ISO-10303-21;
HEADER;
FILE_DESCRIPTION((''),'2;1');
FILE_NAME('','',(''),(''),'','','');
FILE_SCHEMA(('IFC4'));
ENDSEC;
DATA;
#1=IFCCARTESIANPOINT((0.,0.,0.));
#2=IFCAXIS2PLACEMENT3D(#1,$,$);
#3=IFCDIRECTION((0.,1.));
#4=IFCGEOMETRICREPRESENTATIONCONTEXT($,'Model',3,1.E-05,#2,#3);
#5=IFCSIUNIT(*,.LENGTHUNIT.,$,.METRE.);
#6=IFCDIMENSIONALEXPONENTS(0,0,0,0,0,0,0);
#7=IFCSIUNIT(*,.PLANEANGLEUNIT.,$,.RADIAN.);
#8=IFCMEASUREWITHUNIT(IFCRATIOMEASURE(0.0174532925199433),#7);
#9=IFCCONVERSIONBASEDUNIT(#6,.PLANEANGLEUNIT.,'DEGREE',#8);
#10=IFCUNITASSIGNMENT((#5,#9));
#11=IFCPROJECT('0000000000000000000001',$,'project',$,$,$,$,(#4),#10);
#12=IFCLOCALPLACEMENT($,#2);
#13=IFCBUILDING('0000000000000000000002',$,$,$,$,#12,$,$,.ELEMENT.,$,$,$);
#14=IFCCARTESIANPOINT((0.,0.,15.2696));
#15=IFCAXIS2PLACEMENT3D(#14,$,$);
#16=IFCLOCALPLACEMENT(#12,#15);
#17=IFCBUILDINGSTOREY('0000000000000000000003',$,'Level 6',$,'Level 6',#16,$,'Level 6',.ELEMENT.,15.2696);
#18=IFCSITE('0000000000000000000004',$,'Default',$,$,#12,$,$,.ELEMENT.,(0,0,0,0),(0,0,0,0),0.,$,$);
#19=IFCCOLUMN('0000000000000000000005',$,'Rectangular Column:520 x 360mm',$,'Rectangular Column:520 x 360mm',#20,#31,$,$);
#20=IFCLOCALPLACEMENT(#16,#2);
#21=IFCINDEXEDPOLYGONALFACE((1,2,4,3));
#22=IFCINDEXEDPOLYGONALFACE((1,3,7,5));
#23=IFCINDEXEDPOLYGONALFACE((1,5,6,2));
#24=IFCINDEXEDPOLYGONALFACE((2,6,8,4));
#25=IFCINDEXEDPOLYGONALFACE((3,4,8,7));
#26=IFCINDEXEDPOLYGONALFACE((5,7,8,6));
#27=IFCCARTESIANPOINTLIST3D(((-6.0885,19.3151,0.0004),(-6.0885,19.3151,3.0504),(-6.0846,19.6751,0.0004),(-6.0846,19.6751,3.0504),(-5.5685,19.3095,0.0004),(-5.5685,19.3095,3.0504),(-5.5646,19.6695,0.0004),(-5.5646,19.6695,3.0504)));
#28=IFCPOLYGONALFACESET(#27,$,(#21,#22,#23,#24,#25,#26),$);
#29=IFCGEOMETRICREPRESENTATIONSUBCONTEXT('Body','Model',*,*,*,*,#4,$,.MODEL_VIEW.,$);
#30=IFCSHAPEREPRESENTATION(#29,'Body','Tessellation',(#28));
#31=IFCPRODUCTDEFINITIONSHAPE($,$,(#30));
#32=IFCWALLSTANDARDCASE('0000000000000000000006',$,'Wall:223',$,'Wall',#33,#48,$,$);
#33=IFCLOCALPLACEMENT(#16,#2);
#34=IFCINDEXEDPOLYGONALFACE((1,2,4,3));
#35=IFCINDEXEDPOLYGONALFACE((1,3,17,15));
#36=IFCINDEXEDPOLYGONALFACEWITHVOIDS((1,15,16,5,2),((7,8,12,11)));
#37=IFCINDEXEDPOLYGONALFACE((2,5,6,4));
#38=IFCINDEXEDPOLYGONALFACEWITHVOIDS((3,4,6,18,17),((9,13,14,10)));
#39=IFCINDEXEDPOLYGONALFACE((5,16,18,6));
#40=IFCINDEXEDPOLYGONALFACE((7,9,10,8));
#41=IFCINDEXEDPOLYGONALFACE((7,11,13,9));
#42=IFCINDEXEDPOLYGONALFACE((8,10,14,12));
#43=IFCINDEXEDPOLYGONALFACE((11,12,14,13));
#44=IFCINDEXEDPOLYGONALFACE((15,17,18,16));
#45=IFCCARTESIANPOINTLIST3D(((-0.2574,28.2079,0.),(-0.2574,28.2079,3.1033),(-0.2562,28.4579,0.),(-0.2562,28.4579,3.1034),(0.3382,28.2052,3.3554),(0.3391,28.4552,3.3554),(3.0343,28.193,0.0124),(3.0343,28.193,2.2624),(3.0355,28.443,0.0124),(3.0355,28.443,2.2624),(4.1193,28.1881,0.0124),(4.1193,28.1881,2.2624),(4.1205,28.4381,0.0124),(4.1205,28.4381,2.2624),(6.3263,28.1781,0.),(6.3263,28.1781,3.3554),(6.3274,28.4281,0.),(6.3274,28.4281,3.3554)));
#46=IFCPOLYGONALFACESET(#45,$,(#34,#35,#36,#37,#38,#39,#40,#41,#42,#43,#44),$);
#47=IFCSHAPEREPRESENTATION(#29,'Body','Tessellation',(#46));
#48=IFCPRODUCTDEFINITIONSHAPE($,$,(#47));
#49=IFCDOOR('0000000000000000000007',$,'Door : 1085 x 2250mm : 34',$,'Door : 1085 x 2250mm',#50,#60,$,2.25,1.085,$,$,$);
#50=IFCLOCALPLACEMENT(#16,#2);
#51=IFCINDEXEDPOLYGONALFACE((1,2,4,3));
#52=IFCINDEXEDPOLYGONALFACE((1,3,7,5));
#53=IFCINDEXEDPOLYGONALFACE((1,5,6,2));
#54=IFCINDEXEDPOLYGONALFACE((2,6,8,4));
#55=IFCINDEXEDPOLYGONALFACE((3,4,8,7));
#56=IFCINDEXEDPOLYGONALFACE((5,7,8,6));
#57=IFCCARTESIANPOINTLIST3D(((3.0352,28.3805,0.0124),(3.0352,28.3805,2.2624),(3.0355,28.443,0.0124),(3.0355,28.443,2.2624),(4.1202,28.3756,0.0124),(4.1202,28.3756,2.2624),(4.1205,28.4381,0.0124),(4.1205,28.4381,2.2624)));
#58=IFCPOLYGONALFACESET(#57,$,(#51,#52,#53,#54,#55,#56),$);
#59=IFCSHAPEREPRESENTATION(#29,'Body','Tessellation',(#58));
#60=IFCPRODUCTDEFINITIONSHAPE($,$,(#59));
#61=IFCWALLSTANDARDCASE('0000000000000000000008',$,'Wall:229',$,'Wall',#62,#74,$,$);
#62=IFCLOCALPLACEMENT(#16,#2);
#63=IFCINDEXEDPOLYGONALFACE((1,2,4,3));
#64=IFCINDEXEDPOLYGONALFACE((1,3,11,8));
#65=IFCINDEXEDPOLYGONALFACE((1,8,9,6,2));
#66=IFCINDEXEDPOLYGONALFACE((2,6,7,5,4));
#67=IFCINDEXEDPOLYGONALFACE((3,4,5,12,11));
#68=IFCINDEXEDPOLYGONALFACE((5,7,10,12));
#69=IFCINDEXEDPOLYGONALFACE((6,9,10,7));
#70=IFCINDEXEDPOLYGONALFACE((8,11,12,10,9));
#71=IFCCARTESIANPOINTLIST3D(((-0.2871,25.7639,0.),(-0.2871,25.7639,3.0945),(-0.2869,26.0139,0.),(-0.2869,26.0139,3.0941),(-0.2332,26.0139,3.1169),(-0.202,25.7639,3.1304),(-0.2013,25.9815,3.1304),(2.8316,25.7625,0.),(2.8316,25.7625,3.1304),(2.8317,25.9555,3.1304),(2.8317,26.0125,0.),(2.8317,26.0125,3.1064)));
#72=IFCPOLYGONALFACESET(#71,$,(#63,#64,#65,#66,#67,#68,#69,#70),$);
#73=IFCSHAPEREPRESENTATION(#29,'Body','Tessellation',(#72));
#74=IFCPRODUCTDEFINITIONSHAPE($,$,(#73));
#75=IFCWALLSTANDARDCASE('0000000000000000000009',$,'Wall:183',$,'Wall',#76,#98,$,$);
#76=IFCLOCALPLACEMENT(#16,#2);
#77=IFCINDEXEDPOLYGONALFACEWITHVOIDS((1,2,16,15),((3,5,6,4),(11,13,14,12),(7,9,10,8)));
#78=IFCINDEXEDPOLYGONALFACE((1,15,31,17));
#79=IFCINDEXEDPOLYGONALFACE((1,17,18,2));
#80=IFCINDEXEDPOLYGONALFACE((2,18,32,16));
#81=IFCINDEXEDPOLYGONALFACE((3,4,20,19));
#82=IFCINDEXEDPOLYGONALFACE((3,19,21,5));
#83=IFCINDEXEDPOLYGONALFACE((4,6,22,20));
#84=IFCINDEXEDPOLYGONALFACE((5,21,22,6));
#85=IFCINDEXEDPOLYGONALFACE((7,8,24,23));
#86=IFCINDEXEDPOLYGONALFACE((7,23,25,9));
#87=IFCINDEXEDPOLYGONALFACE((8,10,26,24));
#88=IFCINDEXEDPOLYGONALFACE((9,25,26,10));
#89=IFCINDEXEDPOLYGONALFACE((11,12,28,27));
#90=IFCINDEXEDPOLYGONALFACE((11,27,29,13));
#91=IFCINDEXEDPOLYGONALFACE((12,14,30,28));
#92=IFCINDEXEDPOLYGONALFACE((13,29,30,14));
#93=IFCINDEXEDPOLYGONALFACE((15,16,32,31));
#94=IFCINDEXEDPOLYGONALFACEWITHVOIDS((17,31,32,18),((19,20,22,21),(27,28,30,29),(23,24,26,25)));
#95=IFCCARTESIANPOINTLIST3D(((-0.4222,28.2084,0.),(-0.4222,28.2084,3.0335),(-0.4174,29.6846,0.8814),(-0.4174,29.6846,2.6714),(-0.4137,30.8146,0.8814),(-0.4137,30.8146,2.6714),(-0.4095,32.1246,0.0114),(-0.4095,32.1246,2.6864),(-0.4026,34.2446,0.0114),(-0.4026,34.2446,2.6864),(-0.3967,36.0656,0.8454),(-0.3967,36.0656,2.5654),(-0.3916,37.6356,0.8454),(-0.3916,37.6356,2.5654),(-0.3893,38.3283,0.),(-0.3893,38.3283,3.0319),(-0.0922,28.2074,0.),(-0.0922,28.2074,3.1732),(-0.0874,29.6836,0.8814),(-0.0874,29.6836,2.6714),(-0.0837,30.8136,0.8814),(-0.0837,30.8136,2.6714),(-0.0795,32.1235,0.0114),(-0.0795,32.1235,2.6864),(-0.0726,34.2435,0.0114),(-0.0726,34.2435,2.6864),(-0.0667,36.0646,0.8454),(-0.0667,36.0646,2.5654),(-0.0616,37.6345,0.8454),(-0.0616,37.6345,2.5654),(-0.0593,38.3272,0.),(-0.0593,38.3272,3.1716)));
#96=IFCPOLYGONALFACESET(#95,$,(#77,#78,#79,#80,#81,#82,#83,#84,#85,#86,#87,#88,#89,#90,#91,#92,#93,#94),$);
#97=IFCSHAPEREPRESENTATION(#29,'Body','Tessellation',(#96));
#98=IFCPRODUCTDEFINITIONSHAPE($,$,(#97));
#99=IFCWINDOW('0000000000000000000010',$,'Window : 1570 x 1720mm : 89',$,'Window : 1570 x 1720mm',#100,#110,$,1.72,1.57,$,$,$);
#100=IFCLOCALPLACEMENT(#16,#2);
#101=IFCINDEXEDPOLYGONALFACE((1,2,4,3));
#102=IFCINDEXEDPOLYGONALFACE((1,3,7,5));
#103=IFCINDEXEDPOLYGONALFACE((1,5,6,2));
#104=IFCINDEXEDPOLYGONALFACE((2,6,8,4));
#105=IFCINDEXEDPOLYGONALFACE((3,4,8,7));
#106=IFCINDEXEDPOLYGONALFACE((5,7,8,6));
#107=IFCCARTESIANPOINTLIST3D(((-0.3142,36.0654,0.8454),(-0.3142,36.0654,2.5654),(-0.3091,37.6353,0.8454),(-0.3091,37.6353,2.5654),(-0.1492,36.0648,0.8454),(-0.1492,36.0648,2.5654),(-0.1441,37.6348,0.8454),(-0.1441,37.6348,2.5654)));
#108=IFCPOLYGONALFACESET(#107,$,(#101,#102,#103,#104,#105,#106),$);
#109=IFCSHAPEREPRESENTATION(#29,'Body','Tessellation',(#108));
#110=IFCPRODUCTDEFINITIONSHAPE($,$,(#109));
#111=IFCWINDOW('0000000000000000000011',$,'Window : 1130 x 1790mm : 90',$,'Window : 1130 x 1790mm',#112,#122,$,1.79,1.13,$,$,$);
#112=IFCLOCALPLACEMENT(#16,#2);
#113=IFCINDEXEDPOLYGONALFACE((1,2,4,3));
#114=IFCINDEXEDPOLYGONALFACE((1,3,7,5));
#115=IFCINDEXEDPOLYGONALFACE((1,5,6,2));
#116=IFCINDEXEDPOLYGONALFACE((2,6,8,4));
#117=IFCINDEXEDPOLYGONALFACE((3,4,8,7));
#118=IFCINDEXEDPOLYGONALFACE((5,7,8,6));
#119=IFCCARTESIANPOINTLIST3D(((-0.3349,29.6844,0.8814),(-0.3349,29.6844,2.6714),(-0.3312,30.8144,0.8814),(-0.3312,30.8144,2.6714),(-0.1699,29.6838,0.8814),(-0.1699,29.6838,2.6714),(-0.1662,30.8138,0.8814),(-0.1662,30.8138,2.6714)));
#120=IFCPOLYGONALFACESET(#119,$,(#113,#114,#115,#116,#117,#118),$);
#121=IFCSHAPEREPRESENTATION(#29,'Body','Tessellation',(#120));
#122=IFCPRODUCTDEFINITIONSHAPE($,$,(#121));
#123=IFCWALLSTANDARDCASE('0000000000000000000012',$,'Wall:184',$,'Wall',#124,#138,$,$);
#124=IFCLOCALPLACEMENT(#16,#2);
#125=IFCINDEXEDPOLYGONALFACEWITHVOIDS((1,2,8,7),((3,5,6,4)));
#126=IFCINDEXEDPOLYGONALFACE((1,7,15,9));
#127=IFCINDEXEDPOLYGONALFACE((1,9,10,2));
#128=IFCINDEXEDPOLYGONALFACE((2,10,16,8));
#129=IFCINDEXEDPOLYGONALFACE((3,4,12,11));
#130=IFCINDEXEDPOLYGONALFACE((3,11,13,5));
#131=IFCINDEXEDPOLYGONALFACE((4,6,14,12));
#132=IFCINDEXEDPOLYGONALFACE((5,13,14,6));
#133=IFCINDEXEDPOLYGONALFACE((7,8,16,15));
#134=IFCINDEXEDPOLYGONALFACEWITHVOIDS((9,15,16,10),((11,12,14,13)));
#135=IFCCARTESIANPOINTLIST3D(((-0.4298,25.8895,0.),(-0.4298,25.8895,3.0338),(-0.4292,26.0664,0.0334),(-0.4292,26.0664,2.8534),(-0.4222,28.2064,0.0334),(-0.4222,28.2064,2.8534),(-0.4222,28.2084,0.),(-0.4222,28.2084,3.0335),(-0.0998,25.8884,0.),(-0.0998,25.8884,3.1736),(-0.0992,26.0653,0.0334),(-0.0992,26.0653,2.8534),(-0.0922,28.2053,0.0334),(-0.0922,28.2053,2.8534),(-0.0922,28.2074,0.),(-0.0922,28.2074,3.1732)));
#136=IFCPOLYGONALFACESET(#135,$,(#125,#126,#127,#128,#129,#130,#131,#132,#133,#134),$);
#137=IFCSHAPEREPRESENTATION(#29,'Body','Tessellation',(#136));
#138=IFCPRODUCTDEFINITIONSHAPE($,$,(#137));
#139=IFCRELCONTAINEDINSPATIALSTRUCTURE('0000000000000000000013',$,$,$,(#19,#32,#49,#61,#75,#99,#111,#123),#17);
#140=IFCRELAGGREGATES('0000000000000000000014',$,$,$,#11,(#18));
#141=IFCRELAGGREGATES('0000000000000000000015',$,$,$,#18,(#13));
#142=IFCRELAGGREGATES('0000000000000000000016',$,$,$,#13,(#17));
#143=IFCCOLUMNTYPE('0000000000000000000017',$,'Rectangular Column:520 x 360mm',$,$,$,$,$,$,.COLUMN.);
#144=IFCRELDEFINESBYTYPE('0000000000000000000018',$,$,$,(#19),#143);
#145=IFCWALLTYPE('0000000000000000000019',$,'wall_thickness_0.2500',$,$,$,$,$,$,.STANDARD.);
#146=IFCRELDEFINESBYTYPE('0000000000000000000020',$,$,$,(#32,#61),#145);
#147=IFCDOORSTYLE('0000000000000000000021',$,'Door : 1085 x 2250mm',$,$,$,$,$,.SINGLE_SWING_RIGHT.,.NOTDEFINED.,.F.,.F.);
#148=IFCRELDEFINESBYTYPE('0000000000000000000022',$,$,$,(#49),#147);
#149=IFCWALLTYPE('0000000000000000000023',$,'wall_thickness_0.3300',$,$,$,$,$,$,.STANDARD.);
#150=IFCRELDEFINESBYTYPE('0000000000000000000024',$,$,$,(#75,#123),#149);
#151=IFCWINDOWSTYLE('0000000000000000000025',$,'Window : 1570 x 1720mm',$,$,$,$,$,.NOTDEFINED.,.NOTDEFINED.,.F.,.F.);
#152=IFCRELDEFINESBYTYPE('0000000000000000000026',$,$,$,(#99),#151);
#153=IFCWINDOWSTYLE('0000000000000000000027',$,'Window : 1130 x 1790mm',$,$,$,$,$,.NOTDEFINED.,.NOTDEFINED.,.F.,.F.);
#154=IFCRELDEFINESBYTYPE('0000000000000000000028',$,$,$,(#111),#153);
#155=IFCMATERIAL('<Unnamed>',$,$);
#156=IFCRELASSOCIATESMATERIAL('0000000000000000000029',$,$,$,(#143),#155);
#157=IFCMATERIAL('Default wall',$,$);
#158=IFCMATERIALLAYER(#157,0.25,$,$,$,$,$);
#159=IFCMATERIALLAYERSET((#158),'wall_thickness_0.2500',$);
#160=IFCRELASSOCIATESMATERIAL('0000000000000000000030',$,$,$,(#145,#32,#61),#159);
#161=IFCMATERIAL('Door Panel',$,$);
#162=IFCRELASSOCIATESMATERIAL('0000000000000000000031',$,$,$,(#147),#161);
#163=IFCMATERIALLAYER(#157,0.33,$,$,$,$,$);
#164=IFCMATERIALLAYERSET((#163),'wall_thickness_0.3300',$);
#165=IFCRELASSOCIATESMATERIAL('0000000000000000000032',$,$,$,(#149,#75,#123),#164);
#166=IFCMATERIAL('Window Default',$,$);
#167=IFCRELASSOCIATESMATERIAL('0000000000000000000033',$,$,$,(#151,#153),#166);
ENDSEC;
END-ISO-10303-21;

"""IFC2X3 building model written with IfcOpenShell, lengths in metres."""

from ifc_helpers import new_model, entity, si_unit, converted_unit, direction, frame, frame_2d, origin, origin_2d_with_axis, place, context, subcontext, project, spatial, polyline, rectangle, outline, extrude, clip, halfspace, source, transform, mapped, material, layer, layer_set, layer_usage, type_object, type_shapes, element, fill, save


model = new_model("IFC2X3")

# Units and contexts
model_context = context("Model", 3, precision=1e-05, world=origin(), true_north=direction((0.0, 1.0)))
body_context = subcontext(model_context, "Body", "Model", "MODEL_VIEW")
ifc_project = project(units=[si_unit("LENGTHUNIT", "METRE"), converted_unit("PLANEANGLEUNIT", "DEGREE", entity("IfcRatioMeasure", 0.0174532925199433), si_unit("PLANEANGLEUNIT", "RADIAN"), dimensions=[0, 0, 0, 0, 0, 0, 0])], contexts=[model_context])

# Site, building, storey
placement = place(None, origin())
site = spatial("IfcSite", under=ifc_project, at=placement, Name="Default", CompositionType="ELEMENT", RefLatitude=(0, 0, 0, 0), RefLongitude=(0, 0, 0, 0), RefElevation=0.0)
building = spatial("IfcBuilding", under=site, at=placement, CompositionType="ELEMENT")
storey_placement = place(placement, frame((0.0, 0.0, 15.2696)))
storey = spatial("IfcBuildingStorey", under=building, at=storey_placement, Name="Level 6", ObjectType="Level 6", LongName="Level 6", CompositionType="ELEMENT", Elevation=15.2696)

# Column
ifc_material_1 = material(Name="<Unnamed>")
column_type = type_object("IfcColumnType", Name="Rectangular Column:520 x 360mm", PredefinedType="COLUMN", material=ifc_material_1)
shared_shape_1 = source(origin(), body_context, "Body", "SweptSolid", [
    extrude(rectangle(XDim=0.52, YDim=0.36, at=origin_2d_with_axis()), frame((0.0, 0.0, 0.0), z_axis=(0.0, 0.0, 1.0), x_axis=(0.0, -1.0, 0.0)), (0.0, 0.0, 1.0), 3.05),
])
type_shapes(column_type, [shared_shape_1])
column_placement = place(placement, frame((-5.8266, 19.4923, 15.27), z_axis=(0.0, 0.0, 1.0), x_axis=(-0.010821, -0.999941, 0.0)))
element("IfcColumn", 1, at=column_placement, inside=storey, type_object=column_type, Name="Rectangular Column:520 x 360mm", ObjectType="Rectangular Column:520 x 360mm", context=body_context, shape_type="MappedRepresentation", body=[
    mapped(shared_shape_1, transform((0.0, 0.0, 0.0), scale=1.0)),
])

# Shared definitions
ifc_material_2 = material(Name="Default wall")
ifc_layer_1 = layer(ifc_material_2, 0.25)
ifc_layer_set_1 = layer_set([ifc_layer_1], Name="wall_thickness_0.2500")
ifc_layer_usage_1 = layer_usage(ifc_layer_set_1, "AXIS2", "POSITIVE", -0.125)
wall_type_1 = type_object("IfcWallType", Name="wall_thickness_0.2500", PredefinedType="STANDARD", material=ifc_layer_set_1)

# Wall, opening, door
wall_1_placement = place(storey_placement, frame((-0.2568, 28.3329, 0.0), z_axis=(0.0, 0.0, 1.0), x_axis=(0.99999, -0.00453, 0.0)))
wall_1 = element("IfcWallStandardCase", 2, at=wall_1_placement, inside=storey, type_object=wall_type_1, material=ifc_layer_usage_1, Name="Wall:223", ObjectType="Wall", context=body_context, shape_type="Clipping", body=[
    clip(extrude(outline(polyline([(6.5837, -0.125), (6.5837, 0.125), (0.0, 0.125), (0.0, -0.125), (6.5837, -0.125)])), origin(), (0.0, 0.0, 1.0), 3.3554), halfspace(frame((-1.2212, 47.5059, 2.6044), z_axis=(-0.389901, -0.000352, 0.920857), x_axis=(0.920855, -0.001376, 0.389903)), False)),
])
opening_1_placement = place(wall_1_placement, frame((3.2917, -0.125, 0.0124)))
opening_1 = element("IfcOpeningElement", 3, at=opening_1_placement, cuts=wall_1, ObjectType="Opening", context=body_context, shape_type="SweptSolid", body=[
    extrude(rectangle(XDim=1.085, YDim=2.25, at=frame_2d((1.125, 0.5425), x_axis=(0.0, 1.0))), frame((0.0, 0.0, 0.0), z_axis=(0.0, 1.0, 0.0), x_axis=(0.0, 0.0, 1.0)), (0.0, 0.0, 1.0), 0.25),
])
ifc_material_3 = material(Name="Door Panel")
door_style_1 = type_object("IfcDoorStyle", Name="Door : 1085 x 2250mm", ConstructionType="NOTDEFINED", OperationType="SINGLE_SWING_RIGHT", ParameterTakesPrecedence=False, Sizeable=False, material=ifc_material_3)
shared_shape_2 = source(origin(), body_context, "Body", "SweptSolid", [
    extrude(rectangle(XDim=0.0625, YDim=1.085, at=origin_2d_with_axis()), frame((0.5425, 0.2188, 0.0), z_axis=(0.0, 0.0, 1.0), x_axis=(0.0, 1.0, 0.0)), (0.0, 0.0, 1.0), 2.25),
])
type_shapes(door_style_1, [shared_shape_2])
door_1_placement = place(opening_1_placement, origin())
door_1 = element("IfcDoor", 4, at=door_1_placement, inside=storey, type_object=door_style_1, Name="Door : 1085 x 2250mm : 34", ObjectType="Door : 1085 x 2250mm", OverallHeight=2.25, OverallWidth=1.085, context=body_context, shape_type="MappedRepresentation", body=[
    mapped(shared_shape_2, transform((0.0, 0.0, 0.0), scale=1.0)),
])
fill(opening_1, door_1)

# Wall
wall_2_placement = place(storey_placement, frame((-0.287, 25.8889, 0.0), z_axis=(0.0, 0.0, 1.0), x_axis=(1.0, -0.000475, 0.0)))
element("IfcWallStandardCase", 5, at=wall_2_placement, inside=storey, type_object=wall_type_1, material=ifc_layer_usage_1, Name="Wall:229", ObjectType="Wall", context=body_context, shape_type="Clipping", body=[
    clip(clip(extrude(outline(polyline([(3.1187, -0.125), (3.1187, 0.125), (0.0, 0.125), (0.0, -0.125), (3.1187, -0.125)])), origin(), (0.0, 0.0, 1.0), 3.1304), halfspace(frame((24.6699, -6.6404, 5.8904), z_axis=(0.003154, 0.389123, 0.92118), x_axis=(-0.999956, 0.009332, -0.000518)), False)), halfspace(frame((-0.9995, 49.9544, 2.6044), z_axis=(-0.389899, 0.001229, 0.920857), x_axis=(0.920842, -0.00511, 0.389903)), False)),
])

# Wall, openings, windows
ifc_layer_2 = layer(ifc_material_2, 0.33)
ifc_layer_set_2 = layer_set([ifc_layer_2], Name="wall_thickness_0.3300")
ifc_layer_usage_2 = layer_usage(ifc_layer_set_2, "AXIS2", "POSITIVE", -0.165)
wall_type_2 = type_object("IfcWallType", Name="wall_thickness_0.3300", PredefinedType="STANDARD", material=ifc_layer_set_2)
wall_3_placement = place(storey_placement, frame((-0.2243, 38.3278, 0.0), z_axis=(0.0, 0.0, 1.0), x_axis=(-0.003252, -0.999995, 0.0)))
wall_3 = element("IfcWallStandardCase", 6, at=wall_3_placement, inside=storey, type_object=wall_type_2, material=ifc_layer_usage_2, Name="Wall:183", ObjectType="Wall", context=body_context, shape_type="Clipping", body=[
    clip(extrude(outline(polyline([(10.1199, -0.165), (10.1199, 0.165), (0.0, 0.165), (0.0, -0.165), (10.1199, -0.165)])), origin(), (0.0, 0.0, 1.0), 3.1904), halfspace(frame((-37.5125, -1.1605, 2.6044), z_axis=(-0.000147, -0.389901, 0.920857), x_axis=(0.002553, 0.920852, 0.389903)), False)),
])
opening_2_placement = place(wall_3_placement, frame((4.0837, -0.165, 0.0114)))
element("IfcOpeningElement", 7, at=opening_2_placement, cuts=wall_3, ObjectType="Opening", context=body_context, shape_type="SweptSolid", body=[
    extrude(rectangle(XDim=2.12, YDim=2.675, at=frame_2d((1.3375, 1.06), x_axis=(0.0, 1.0))), frame((0.0, 0.0, 0.0), z_axis=(0.0, 1.0, 0.0), x_axis=(0.0, 0.0, 1.0)), (0.0, 0.0, 1.0), 0.33),
])
opening_3_placement = place(wall_3_placement, frame((0.6927, -0.165, 0.8454)))
opening_3 = element("IfcOpeningElement", 8, at=opening_3_placement, cuts=wall_3, ObjectType="Opening", context=body_context, shape_type="SweptSolid", body=[
    extrude(rectangle(XDim=1.57, YDim=1.72, at=frame_2d((0.86, 0.785), x_axis=(0.0, 1.0))), frame((0.0, 0.0, 0.0), z_axis=(0.0, 1.0, 0.0), x_axis=(0.0, 0.0, 1.0)), (0.0, 0.0, 1.0), 0.33),
])
opening_4_placement = place(wall_3_placement, frame((7.5137, -0.165, 0.8814)))
opening_4 = element("IfcOpeningElement", 9, at=opening_4_placement, cuts=wall_3, ObjectType="Opening", context=body_context, shape_type="SweptSolid", body=[
    extrude(rectangle(XDim=1.13, YDim=1.79, at=frame_2d((0.895, 0.565), x_axis=(0.0, 1.0))), frame((0.0, 0.0, 0.0), z_axis=(0.0, 1.0, 0.0), x_axis=(0.0, 0.0, 1.0)), (0.0, 0.0, 1.0), 0.33),
])
ifc_material_4 = material(Name="Window Default")
window_style_1 = type_object("IfcWindowStyle", Name="Window : 1570 x 1720mm", ConstructionType="NOTDEFINED", OperationType="NOTDEFINED", ParameterTakesPrecedence=False, Sizeable=False, material=ifc_material_4)
shared_shape_3 = source(origin(), body_context, "Body", "SweptSolid", [
    extrude(rectangle(XDim=0.165, YDim=1.57, at=origin_2d_with_axis()), frame((0.785, 0.165, 0.0), z_axis=(0.0, 0.0, 1.0), x_axis=(0.0, 1.0, 0.0)), (0.0, 0.0, 1.0), 1.72),
])
type_shapes(window_style_1, [shared_shape_3])
window_1_placement = place(opening_3_placement, origin())
window_1 = element("IfcWindow", 10, at=window_1_placement, inside=storey, type_object=window_style_1, Name="Window : 1570 x 1720mm : 89", ObjectType="Window : 1570 x 1720mm", OverallHeight=1.72, OverallWidth=1.57, context=body_context, shape_type="MappedRepresentation", body=[
    mapped(shared_shape_3, transform((0.0, 0.0, 0.0), scale=1.0)),
])
fill(opening_3, window_1)
window_style_2 = type_object("IfcWindowStyle", Name="Window : 1130 x 1790mm", ConstructionType="NOTDEFINED", OperationType="NOTDEFINED", ParameterTakesPrecedence=False, Sizeable=False, material=ifc_material_4)
shared_shape_4 = source(origin(), body_context, "Body", "SweptSolid", [
    extrude(rectangle(XDim=0.165, YDim=1.13, at=origin_2d_with_axis()), frame((0.565, 0.165, 0.0), z_axis=(0.0, 0.0, 1.0), x_axis=(0.0, 1.0, 0.0)), (0.0, 0.0, 1.0), 1.79),
])
type_shapes(window_style_2, [shared_shape_4])
window_2_placement = place(opening_4_placement, origin())
window_2 = element("IfcWindow", 11, at=window_2_placement, inside=storey, type_object=window_style_2, Name="Window : 1130 x 1790mm : 90", ObjectType="Window : 1130 x 1790mm", OverallHeight=1.79, OverallWidth=1.13, context=body_context, shape_type="MappedRepresentation", body=[
    mapped(shared_shape_4, transform((0.0, 0.0, 0.0), scale=1.0)),
])
fill(opening_4, window_2)

# Wall, opening
wall_4_placement = place(storey_placement, frame((-0.2572, 28.2079, 0.0), z_axis=(0.0, 0.0, 1.0), x_axis=(-0.003252, -0.999995, 0.0)))
wall_4 = element("IfcWallStandardCase", 12, at=wall_4_placement, inside=storey, type_object=wall_type_2, material=ifc_layer_usage_2, Name="Wall:184", ObjectType="Wall", context=body_context, shape_type="Clipping", body=[
    clip(extrude(outline(polyline([(2.319, -0.165), (2.319, 0.165), (0.0, 0.165), (0.0, -0.165), (2.319, -0.165)])), origin(), (0.0, 0.0, 1.0), 3.1904), halfspace(frame((-47.6324, -1.1605, 2.6044), z_axis=(-0.000147, -0.389901, 0.920857), x_axis=(0.002553, 0.920852, 0.389903)), False)),
])
opening_5_placement = place(wall_4_placement, frame((0.0021, -0.165, 0.0334)))
element("IfcOpeningElement", 13, at=opening_5_placement, cuts=wall_4, ObjectType="Opening", context=body_context, shape_type="SweptSolid", body=[
    extrude(rectangle(XDim=2.14, YDim=2.82, at=frame_2d((1.41, 1.07), x_axis=(0.0, 1.0))), frame((0.0, 0.0, 0.0), z_axis=(0.0, 1.0, 0.0), x_axis=(0.0, 0.0, 1.0)), (0.0, 0.0, 1.0), 0.33),
])

save(model, "model.ifc")
